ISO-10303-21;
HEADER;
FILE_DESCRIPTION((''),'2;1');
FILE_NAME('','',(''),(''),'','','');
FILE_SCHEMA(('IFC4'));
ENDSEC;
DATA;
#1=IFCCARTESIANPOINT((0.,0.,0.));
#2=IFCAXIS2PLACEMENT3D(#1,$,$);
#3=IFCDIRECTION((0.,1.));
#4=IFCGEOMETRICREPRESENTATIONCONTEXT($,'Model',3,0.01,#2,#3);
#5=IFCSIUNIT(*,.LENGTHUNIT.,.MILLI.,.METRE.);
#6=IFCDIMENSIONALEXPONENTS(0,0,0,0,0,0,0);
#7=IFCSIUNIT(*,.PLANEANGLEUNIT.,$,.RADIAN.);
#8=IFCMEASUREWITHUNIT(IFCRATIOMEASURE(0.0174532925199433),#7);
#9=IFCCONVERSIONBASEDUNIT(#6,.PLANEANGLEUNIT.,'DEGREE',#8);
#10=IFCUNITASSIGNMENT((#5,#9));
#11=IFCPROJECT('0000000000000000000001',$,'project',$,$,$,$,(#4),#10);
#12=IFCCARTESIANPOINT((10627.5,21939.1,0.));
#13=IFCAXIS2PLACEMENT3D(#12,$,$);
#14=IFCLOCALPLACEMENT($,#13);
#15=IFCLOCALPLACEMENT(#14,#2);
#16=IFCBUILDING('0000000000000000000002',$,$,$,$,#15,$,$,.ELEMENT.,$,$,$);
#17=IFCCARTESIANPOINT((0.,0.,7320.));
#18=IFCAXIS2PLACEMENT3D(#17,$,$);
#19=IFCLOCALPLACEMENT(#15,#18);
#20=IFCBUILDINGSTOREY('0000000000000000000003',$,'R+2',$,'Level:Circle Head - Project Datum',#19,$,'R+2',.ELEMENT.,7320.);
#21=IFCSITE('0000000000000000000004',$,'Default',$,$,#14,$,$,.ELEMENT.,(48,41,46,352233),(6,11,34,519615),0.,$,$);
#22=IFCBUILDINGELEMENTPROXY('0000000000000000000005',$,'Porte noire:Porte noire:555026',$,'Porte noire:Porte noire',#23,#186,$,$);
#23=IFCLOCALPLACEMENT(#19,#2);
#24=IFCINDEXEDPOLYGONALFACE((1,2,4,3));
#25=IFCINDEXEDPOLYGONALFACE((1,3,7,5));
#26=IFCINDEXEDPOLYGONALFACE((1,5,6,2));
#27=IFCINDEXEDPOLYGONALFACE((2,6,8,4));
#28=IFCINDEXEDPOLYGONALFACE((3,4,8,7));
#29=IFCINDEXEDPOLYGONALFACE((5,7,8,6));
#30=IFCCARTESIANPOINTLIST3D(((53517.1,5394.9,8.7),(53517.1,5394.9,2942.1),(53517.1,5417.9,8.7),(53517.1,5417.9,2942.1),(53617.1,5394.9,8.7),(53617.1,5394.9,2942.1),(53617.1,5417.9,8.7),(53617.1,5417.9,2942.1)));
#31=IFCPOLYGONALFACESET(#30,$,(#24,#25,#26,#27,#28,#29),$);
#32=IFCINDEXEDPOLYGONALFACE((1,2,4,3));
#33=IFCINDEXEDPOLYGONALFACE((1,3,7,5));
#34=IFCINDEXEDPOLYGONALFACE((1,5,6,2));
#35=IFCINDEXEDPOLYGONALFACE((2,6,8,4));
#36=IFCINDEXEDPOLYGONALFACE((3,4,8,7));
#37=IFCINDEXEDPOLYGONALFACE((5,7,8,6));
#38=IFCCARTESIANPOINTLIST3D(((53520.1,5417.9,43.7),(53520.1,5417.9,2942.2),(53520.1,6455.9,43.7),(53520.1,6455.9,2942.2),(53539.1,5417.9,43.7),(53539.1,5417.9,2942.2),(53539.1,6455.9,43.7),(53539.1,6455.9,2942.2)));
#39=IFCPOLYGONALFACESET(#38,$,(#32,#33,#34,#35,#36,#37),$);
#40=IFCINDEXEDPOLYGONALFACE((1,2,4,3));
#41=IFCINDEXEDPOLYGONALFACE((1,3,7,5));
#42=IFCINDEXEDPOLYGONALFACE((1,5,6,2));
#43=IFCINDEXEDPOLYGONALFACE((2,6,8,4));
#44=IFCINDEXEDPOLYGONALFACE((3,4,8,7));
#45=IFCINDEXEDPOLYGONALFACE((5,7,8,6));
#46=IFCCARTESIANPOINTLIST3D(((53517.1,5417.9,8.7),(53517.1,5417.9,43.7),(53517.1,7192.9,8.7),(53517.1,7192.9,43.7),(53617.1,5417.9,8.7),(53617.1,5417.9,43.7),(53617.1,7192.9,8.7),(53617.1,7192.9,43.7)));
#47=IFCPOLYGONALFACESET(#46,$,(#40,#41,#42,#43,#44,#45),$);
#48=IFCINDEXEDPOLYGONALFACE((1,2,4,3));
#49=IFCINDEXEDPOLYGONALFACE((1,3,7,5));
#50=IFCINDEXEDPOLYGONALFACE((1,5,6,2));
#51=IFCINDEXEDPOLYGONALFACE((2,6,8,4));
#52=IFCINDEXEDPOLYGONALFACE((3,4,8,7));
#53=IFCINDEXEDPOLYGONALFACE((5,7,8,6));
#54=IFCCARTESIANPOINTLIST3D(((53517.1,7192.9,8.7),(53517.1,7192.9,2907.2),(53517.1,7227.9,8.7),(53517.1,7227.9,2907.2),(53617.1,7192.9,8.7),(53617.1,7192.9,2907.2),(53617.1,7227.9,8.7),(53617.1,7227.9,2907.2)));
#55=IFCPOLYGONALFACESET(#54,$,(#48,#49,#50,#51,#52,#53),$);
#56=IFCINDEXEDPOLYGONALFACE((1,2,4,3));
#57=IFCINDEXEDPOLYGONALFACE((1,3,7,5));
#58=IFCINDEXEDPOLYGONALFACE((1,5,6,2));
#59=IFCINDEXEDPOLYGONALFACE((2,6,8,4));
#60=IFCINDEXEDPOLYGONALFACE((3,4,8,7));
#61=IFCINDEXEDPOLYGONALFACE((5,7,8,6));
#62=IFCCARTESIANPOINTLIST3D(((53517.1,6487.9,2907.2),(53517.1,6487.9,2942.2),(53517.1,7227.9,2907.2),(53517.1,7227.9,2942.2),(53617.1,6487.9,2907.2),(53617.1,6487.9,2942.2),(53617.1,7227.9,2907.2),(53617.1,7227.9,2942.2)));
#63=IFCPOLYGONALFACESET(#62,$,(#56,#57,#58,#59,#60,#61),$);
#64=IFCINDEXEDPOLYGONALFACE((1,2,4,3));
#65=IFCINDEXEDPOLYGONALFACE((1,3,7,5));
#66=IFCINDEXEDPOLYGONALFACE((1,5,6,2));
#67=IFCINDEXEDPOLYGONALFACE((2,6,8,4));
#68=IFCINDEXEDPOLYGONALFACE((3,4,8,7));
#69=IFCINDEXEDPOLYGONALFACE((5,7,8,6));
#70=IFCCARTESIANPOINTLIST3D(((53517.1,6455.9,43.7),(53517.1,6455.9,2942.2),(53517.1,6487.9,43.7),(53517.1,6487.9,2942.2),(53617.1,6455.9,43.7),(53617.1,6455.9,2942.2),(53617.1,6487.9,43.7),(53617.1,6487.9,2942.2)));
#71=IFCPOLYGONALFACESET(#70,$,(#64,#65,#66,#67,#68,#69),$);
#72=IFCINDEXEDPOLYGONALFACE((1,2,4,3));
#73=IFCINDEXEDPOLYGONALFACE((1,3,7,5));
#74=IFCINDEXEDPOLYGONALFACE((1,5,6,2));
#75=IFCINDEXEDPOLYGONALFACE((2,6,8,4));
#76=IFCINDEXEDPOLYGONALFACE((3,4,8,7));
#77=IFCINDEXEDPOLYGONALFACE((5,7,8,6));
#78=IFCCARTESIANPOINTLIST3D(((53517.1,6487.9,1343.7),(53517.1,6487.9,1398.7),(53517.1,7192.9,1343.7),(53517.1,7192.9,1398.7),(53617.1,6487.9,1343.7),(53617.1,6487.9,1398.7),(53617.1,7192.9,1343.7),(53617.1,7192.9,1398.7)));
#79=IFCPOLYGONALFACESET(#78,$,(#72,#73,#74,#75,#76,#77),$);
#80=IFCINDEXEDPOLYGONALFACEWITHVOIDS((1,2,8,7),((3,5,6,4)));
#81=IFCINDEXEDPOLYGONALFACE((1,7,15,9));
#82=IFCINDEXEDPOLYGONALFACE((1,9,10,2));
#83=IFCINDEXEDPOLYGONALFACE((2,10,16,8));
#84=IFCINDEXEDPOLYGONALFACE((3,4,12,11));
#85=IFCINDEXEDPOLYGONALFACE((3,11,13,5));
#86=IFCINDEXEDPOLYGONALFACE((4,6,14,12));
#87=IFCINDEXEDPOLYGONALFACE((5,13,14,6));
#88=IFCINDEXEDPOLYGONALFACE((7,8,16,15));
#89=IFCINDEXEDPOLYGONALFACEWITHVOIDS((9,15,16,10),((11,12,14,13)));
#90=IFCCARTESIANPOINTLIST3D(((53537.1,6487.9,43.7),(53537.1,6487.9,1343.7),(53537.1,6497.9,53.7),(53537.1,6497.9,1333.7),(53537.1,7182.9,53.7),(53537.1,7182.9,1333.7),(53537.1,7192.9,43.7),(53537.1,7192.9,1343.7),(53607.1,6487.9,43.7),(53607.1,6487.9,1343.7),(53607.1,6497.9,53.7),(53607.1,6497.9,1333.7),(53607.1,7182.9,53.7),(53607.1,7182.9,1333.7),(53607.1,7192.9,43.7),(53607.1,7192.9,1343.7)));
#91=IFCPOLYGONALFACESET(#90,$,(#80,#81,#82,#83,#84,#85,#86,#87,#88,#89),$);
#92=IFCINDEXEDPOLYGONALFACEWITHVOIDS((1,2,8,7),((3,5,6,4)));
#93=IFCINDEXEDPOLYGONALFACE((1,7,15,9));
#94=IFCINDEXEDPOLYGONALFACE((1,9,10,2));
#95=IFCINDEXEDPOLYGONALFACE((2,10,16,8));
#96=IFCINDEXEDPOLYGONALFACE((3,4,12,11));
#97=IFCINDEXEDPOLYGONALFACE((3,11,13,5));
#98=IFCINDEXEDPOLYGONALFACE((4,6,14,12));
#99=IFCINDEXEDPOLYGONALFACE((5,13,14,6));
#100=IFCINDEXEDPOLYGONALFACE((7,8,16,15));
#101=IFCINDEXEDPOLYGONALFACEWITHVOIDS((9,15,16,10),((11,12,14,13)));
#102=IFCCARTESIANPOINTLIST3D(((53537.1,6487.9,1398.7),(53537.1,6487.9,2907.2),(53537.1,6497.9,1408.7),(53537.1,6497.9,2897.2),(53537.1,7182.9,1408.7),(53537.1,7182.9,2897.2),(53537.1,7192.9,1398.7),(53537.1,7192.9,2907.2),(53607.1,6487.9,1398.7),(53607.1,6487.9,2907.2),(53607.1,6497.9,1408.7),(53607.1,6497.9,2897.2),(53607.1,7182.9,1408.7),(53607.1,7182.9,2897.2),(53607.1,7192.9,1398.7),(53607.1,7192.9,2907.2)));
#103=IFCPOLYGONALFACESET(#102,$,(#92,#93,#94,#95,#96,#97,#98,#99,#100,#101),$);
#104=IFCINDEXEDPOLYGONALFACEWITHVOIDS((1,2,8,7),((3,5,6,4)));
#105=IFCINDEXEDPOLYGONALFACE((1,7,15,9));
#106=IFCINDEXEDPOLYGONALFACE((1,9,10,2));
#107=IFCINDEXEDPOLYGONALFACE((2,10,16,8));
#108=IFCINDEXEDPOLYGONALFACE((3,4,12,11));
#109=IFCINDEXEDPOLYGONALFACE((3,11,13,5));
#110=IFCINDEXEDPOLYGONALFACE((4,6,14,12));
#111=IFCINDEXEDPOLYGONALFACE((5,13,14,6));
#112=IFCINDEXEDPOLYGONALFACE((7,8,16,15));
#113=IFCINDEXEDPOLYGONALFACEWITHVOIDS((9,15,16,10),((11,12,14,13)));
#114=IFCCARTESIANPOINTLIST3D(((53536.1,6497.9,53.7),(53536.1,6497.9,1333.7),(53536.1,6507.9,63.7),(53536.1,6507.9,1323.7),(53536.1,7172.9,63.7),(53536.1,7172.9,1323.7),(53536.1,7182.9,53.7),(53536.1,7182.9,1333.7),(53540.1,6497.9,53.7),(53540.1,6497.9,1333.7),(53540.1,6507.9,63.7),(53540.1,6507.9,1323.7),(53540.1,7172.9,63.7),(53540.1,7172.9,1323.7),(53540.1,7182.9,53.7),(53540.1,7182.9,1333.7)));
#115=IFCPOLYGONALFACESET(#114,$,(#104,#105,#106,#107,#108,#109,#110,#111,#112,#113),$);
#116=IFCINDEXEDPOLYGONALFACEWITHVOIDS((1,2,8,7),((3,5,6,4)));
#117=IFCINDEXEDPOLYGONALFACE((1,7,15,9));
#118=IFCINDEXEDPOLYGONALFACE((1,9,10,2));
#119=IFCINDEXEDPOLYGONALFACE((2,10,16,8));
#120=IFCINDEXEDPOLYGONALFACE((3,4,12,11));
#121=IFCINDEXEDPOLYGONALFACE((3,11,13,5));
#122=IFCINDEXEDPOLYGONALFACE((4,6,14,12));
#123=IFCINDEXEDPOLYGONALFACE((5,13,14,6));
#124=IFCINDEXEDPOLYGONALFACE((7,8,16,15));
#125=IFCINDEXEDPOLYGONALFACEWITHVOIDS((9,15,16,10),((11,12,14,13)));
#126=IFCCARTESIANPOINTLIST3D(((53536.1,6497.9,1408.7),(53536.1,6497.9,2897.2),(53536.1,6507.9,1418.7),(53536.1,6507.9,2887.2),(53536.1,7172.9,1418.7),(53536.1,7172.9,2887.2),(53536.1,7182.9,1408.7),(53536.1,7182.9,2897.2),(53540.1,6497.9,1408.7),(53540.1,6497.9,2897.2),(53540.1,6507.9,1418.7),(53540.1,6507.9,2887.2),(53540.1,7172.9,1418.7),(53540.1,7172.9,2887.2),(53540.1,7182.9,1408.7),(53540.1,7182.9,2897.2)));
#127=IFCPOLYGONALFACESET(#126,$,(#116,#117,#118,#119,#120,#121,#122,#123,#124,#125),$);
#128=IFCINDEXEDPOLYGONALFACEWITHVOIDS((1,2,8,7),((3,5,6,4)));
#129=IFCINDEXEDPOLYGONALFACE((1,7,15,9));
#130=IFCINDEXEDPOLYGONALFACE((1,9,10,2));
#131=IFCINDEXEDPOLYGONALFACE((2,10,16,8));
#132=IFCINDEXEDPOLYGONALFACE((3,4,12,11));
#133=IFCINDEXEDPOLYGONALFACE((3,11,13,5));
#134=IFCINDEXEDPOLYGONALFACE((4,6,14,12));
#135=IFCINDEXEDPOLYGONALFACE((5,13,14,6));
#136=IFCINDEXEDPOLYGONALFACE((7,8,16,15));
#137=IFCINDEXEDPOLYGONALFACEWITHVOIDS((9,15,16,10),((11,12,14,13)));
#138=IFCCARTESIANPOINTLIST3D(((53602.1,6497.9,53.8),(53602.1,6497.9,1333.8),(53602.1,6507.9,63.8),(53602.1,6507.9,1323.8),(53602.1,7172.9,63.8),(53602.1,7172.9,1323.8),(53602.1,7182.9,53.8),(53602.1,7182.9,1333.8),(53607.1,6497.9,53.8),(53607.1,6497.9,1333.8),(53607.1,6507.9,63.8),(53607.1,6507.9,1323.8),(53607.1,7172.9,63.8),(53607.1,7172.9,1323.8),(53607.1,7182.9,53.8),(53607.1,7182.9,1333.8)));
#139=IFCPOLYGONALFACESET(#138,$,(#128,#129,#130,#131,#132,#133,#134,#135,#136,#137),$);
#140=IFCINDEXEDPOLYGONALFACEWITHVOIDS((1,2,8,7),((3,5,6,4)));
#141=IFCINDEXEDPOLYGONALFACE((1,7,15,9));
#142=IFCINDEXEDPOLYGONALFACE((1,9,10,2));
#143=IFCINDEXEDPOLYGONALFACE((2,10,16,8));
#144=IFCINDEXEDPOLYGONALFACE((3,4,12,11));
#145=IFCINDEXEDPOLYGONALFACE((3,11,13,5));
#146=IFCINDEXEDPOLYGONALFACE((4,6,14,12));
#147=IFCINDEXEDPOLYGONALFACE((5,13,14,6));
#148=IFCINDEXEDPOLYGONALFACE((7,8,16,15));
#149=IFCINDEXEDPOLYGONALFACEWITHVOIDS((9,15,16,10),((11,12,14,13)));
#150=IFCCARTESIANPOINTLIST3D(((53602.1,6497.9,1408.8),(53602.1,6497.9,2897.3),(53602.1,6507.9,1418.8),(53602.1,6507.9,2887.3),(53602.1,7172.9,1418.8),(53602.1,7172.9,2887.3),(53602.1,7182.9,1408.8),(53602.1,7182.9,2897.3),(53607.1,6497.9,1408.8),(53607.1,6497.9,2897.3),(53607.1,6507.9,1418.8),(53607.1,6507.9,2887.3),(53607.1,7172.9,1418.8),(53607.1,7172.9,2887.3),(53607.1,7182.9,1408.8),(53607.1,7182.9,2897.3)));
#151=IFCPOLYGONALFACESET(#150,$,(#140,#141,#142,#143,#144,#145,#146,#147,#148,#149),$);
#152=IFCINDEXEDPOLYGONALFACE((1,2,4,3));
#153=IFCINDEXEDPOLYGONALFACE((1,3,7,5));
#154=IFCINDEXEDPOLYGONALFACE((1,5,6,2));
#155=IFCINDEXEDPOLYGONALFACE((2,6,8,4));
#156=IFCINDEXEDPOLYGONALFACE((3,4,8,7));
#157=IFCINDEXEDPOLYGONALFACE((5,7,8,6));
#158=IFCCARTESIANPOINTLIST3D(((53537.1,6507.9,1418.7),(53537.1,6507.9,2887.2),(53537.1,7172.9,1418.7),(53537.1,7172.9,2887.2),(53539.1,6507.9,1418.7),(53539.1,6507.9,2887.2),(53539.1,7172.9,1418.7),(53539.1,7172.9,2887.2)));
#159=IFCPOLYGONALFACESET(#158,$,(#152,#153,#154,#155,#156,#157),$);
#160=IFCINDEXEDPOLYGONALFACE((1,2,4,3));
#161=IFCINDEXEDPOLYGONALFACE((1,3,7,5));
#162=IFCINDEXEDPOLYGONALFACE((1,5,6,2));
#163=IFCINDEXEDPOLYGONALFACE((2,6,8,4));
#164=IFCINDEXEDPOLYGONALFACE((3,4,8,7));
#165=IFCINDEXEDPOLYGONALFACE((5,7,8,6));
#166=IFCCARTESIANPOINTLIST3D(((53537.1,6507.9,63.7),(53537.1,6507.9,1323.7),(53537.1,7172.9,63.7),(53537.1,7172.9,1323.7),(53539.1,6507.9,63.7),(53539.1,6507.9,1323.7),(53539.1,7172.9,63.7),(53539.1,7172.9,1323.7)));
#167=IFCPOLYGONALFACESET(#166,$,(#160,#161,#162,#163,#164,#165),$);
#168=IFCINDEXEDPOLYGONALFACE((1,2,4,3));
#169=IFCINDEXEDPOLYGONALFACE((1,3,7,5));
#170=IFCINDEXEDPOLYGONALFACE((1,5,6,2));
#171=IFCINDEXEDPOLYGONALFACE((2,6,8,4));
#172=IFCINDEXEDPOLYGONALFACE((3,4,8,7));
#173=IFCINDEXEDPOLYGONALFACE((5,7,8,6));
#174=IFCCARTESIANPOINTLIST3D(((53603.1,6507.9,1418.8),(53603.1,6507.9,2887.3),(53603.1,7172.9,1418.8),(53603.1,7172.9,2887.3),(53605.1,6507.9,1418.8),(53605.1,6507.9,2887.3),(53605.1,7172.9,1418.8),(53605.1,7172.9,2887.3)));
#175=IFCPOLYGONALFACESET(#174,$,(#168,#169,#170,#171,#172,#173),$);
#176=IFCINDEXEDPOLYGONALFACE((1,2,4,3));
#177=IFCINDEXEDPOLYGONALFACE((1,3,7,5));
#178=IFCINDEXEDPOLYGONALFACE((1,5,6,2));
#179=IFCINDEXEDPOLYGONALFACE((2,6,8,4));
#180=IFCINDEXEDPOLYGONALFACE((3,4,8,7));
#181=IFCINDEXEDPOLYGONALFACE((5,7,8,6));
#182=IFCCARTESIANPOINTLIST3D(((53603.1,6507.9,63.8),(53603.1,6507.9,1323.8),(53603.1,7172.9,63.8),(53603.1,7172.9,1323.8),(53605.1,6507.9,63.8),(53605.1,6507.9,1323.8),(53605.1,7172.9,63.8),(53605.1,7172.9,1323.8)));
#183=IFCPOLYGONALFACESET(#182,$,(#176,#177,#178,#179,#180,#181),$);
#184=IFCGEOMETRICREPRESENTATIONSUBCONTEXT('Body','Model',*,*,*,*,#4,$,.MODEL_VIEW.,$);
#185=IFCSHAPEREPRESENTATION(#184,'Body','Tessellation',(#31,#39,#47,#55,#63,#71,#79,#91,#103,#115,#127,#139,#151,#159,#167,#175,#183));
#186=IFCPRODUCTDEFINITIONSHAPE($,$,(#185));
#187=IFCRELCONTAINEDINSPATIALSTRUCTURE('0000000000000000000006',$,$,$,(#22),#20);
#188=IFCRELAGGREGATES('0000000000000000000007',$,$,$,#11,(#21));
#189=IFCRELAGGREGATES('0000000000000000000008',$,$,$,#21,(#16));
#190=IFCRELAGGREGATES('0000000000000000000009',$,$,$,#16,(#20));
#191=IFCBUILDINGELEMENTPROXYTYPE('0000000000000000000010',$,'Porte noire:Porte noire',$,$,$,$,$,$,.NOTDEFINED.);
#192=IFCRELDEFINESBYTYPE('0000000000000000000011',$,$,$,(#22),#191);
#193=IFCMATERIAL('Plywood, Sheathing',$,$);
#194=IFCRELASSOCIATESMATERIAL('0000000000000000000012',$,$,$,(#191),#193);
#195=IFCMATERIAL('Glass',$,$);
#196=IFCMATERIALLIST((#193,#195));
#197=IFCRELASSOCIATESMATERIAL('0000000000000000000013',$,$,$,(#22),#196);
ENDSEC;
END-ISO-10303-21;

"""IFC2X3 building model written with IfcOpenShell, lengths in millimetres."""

from ifc_helpers import new_model, entity, si_unit, converted_unit, direction, frame, frame_2d, origin, origin_2d_with_axis, place, context, subcontext, project, spatial, polyline, rectangle, outline, extrude, source, transform, mapped, material, material_list, type_object, type_shapes, element, save


model = new_model("IFC2X3")

# Units and contexts
model_context = context("Model", 3, precision=0.01, world=origin(), true_north=direction((0.0, 1.0)))
body_context = subcontext(model_context, "Body", "Model", "MODEL_VIEW")
ifc_project = project(units=[si_unit("LENGTHUNIT", "METRE", prefix="MILLI"), converted_unit("PLANEANGLEUNIT", "DEGREE", entity("IfcRatioMeasure", 0.0174532925199433), si_unit("PLANEANGLEUNIT", "RADIAN"), dimensions=[0, 0, 0, 0, 0, 0, 0])], contexts=[model_context])

# Site, building, storey
site_placement = place(None, frame((10627.5, 21939.1, 0.0)))
site = spatial("IfcSite", under=ifc_project, at=site_placement, Name="Default", CompositionType="ELEMENT", RefLatitude=(48, 41, 46, 352233), RefLongitude=(6, 11, 34, 519615), RefElevation=0.0)
building_placement = place(site_placement, origin())
building = spatial("IfcBuilding", under=site, at=building_placement, CompositionType="ELEMENT")
storey_placement = place(building_placement, frame((0.0, 0.0, 7320.0)))
storey = spatial("IfcBuildingStorey", under=building, at=storey_placement, Name="R+2", ObjectType="Level:Circle Head - Project Datum", LongName="R+2", CompositionType="ELEMENT", Elevation=7320.0)

# Building element proxy
ifc_material_1 = material(Name="Glass")
ifc_material_2 = material(Name="Plywood, Sheathing")
building_element_proxy_type_1 = type_object("IfcBuildingElementProxyType", Name="Porte noire:Porte noire", PredefinedType="NOTDEFINED", material=ifc_material_2)
shared_shape_1 = source(origin(), body_context, "Body", "SweptSolid", [
    extrude(rectangle(XDim=23.0, YDim=100.0, at=frame_2d((0.0, 0.0), x_axis=(1.0, 0.0))), frame((-950.9, 50.0, 8.7), z_axis=(0.0, 0.0, 1.0), x_axis=(-1.0, 0.0, 0.0)), (0.0, 0.0, 1.0), 2933.3),
    extrude(rectangle(XDim=1038.0, YDim=19.0, at=frame_2d((0.0, 0.0), x_axis=(1.0, 0.0))), frame((-420.4, 87.5, 43.7), z_axis=(0.0, 0.0, 1.0), x_axis=(-1.0, 0.0, 0.0)), (0.0, 0.0, 1.0), 2898.5),
    extrude(rectangle(XDim=1775.0, YDim=100.0, at=origin_2d_with_axis()), frame((-51.9, 50.0, 8.7), z_axis=(0.0, 0.0, 1.0), x_axis=(-1.0, 0.0, 0.0)), (0.0, 0.0, 1.0), 35.0),
    extrude(rectangle(XDim=35.0, YDim=100.0, at=origin_2d_with_axis()), frame((853.1, 50.0, 8.7), z_axis=(0.0, 0.0, 1.0), x_axis=(-1.0, 0.0, 0.0)), (0.0, 0.0, 1.0), 2898.5),
    extrude(rectangle(XDim=740.0, YDim=100.0, at=origin_2d_with_axis()), frame((500.6, 50.0, 2907.2), z_axis=(0.0, 0.0, 1.0), x_axis=(-1.0, 0.0, 0.0)), (0.0, 0.0, 1.0), 35.0),
    extrude(rectangle(XDim=32.0, YDim=100.0, at=origin_2d_with_axis()), frame((114.6, 50.0, 43.7), z_axis=(0.0, 0.0, 1.0), x_axis=(-1.0, 0.0, 0.0)), (0.0, 0.0, 1.0), 2898.5),
    extrude(rectangle(XDim=705.0, YDim=100.0, at=origin_2d_with_axis()), frame((483.1, 50.0, 1343.7), z_axis=(0.0, 0.0, 1.0), x_axis=(-1.0, 0.0, 0.0)), (0.0, 0.0, 1.0), 55.0),
    extrude(outline(polyline([(-352.5, -650.0), (352.5, -650.0), (352.5, 650.0), (-352.5, 650.0), (-352.5, -650.0)]), holes=[polyline([(342.5, 640.0), (342.5, -640.0), (-342.5, -640.0), (-342.5, 640.0), (342.5, 640.0)])]), frame((483.1, 10.0, 693.7), z_axis=(0.0, 1.0, 0.0), x_axis=(1.0, 0.0, 0.0)), (0.0, 0.0, 1.0), 70.0),
    extrude(outline(polyline([(-754.2, -352.5), (754.2, -352.5), (754.2, 352.5), (-754.2, 352.5), (-754.2, -352.5)]), holes=[polyline([(744.2, 342.5), (744.2, -342.5), (-744.2, -342.5), (-744.2, 342.5), (744.2, 342.5)])]), frame((483.1, 10.0, 2153.0), z_axis=(0.0, 1.0, 0.0), x_axis=(0.0, 0.0, 1.0)), (0.0, 0.0, 1.0), 70.0),
    extrude(outline(polyline([(-640.0, -342.5), (640.0, -342.5), (640.0, 342.5), (-640.0, 342.5), (-640.0, -342.5)]), holes=[polyline([(630.0, 332.5), (630.0, -332.5), (-630.0, -332.5), (-630.0, 332.5), (630.0, 332.5)])]), frame((483.1, 77.0, 693.7), z_axis=(0.0, 1.0, 0.0), x_axis=(0.0, 0.0, 1.0)), (0.0, 0.0, 1.0), 4.0),
    extrude(outline(polyline([(-744.2, -342.5), (744.2, -342.5), (744.2, 342.5), (-744.2, 342.5), (-744.2, -342.5)]), holes=[polyline([(734.2, 332.5), (734.2, -332.5), (-734.2, -332.5), (-734.2, 332.5), (734.2, 332.5)])]), frame((483.1, 77.0, 2153.0), z_axis=(0.0, 1.0, 0.0), x_axis=(0.0, 0.0, 1.0)), (0.0, 0.0, 1.0), 4.0),
    extrude(outline(polyline([(-640.0, -342.5), (640.0, -342.5), (640.0, 342.5), (-640.0, 342.5), (-640.0, -342.5)]), holes=[polyline([(630.0, 332.5), (630.0, -332.5), (-630.0, -332.5), (-630.0, 332.5), (630.0, 332.5)])]), frame((483.1, 10.0, 693.8), z_axis=(0.0, 1.0, 0.0), x_axis=(0.0, 0.0, 1.0)), (0.0, 0.0, 1.0), 5.0),
    extrude(outline(polyline([(-744.2, -342.5), (744.2, -342.5), (744.2, 342.5), (-744.2, 342.5), (-744.2, -342.5)]), holes=[polyline([(734.2, 332.5), (734.2, -332.5), (-734.2, -332.5), (-734.2, 332.5), (734.2, 332.5)])]), frame((483.1, 10.0, 2153.0), z_axis=(0.0, 1.0, 0.0), x_axis=(0.0, 0.0, 1.0)), (0.0, 0.0, 1.0), 5.0),
    extrude(rectangle(XDim=665.0, YDim=2.0, at=frame_2d((0.0, 0.0), x_axis=(1.0, 0.0))), frame((483.1, 79.0, 1418.7), z_axis=(0.0, 0.0, 1.0), x_axis=(-1.0, 0.0, 0.0)), (0.0, 0.0, 1.0), 1468.5),
    extrude(rectangle(XDim=665.0, YDim=2.0, at=frame_2d((0.0, 0.0), x_axis=(1.0, 0.0))), frame((483.1, 79.0, 63.7), z_axis=(0.0, 0.0, 1.0), x_axis=(-1.0, 0.0, 0.0)), (0.0, 0.0, 1.0), 1260.0),
    extrude(rectangle(XDim=665.0, YDim=2.0, at=frame_2d((0.0, 0.0), x_axis=(1.0, 0.0))), frame((483.1, 13.0, 1418.8), z_axis=(0.0, 0.0, 1.0), x_axis=(-1.0, 0.0, 0.0)), (0.0, 0.0, 1.0), 1468.5),
    extrude(rectangle(XDim=665.0, YDim=2.0, at=frame_2d((0.0, 0.0), x_axis=(1.0, 0.0))), frame((483.1, 13.0, 63.8), z_axis=(0.0, 0.0, 1.0), x_axis=(-1.0, 0.0, 0.0)), (0.0, 0.0, 1.0), 1260.0),
])
type_shapes(building_element_proxy_type_1, [shared_shape_1])
ifc_material_list_1 = material_list([ifc_material_2, ifc_material_1])
proxy_1_placement = place(storey_placement, frame((53617.1, 6357.3, 0.0), z_axis=(0.0, 0.0, 1.0), x_axis=(0.0, 1.0, 0.0)))
element("IfcBuildingElementProxy", 1, at=proxy_1_placement, inside=storey, type_object=building_element_proxy_type_1, material=ifc_material_list_1, Name="Porte noire:Porte noire:555026", ObjectType="Porte noire:Porte noire", context=body_context, shape_type="MappedRepresentation", body=[
    mapped(shared_shape_1, transform((0.0, 0.0, 0.0), scale=1.0)),
])

save(model, "model.ifc")
